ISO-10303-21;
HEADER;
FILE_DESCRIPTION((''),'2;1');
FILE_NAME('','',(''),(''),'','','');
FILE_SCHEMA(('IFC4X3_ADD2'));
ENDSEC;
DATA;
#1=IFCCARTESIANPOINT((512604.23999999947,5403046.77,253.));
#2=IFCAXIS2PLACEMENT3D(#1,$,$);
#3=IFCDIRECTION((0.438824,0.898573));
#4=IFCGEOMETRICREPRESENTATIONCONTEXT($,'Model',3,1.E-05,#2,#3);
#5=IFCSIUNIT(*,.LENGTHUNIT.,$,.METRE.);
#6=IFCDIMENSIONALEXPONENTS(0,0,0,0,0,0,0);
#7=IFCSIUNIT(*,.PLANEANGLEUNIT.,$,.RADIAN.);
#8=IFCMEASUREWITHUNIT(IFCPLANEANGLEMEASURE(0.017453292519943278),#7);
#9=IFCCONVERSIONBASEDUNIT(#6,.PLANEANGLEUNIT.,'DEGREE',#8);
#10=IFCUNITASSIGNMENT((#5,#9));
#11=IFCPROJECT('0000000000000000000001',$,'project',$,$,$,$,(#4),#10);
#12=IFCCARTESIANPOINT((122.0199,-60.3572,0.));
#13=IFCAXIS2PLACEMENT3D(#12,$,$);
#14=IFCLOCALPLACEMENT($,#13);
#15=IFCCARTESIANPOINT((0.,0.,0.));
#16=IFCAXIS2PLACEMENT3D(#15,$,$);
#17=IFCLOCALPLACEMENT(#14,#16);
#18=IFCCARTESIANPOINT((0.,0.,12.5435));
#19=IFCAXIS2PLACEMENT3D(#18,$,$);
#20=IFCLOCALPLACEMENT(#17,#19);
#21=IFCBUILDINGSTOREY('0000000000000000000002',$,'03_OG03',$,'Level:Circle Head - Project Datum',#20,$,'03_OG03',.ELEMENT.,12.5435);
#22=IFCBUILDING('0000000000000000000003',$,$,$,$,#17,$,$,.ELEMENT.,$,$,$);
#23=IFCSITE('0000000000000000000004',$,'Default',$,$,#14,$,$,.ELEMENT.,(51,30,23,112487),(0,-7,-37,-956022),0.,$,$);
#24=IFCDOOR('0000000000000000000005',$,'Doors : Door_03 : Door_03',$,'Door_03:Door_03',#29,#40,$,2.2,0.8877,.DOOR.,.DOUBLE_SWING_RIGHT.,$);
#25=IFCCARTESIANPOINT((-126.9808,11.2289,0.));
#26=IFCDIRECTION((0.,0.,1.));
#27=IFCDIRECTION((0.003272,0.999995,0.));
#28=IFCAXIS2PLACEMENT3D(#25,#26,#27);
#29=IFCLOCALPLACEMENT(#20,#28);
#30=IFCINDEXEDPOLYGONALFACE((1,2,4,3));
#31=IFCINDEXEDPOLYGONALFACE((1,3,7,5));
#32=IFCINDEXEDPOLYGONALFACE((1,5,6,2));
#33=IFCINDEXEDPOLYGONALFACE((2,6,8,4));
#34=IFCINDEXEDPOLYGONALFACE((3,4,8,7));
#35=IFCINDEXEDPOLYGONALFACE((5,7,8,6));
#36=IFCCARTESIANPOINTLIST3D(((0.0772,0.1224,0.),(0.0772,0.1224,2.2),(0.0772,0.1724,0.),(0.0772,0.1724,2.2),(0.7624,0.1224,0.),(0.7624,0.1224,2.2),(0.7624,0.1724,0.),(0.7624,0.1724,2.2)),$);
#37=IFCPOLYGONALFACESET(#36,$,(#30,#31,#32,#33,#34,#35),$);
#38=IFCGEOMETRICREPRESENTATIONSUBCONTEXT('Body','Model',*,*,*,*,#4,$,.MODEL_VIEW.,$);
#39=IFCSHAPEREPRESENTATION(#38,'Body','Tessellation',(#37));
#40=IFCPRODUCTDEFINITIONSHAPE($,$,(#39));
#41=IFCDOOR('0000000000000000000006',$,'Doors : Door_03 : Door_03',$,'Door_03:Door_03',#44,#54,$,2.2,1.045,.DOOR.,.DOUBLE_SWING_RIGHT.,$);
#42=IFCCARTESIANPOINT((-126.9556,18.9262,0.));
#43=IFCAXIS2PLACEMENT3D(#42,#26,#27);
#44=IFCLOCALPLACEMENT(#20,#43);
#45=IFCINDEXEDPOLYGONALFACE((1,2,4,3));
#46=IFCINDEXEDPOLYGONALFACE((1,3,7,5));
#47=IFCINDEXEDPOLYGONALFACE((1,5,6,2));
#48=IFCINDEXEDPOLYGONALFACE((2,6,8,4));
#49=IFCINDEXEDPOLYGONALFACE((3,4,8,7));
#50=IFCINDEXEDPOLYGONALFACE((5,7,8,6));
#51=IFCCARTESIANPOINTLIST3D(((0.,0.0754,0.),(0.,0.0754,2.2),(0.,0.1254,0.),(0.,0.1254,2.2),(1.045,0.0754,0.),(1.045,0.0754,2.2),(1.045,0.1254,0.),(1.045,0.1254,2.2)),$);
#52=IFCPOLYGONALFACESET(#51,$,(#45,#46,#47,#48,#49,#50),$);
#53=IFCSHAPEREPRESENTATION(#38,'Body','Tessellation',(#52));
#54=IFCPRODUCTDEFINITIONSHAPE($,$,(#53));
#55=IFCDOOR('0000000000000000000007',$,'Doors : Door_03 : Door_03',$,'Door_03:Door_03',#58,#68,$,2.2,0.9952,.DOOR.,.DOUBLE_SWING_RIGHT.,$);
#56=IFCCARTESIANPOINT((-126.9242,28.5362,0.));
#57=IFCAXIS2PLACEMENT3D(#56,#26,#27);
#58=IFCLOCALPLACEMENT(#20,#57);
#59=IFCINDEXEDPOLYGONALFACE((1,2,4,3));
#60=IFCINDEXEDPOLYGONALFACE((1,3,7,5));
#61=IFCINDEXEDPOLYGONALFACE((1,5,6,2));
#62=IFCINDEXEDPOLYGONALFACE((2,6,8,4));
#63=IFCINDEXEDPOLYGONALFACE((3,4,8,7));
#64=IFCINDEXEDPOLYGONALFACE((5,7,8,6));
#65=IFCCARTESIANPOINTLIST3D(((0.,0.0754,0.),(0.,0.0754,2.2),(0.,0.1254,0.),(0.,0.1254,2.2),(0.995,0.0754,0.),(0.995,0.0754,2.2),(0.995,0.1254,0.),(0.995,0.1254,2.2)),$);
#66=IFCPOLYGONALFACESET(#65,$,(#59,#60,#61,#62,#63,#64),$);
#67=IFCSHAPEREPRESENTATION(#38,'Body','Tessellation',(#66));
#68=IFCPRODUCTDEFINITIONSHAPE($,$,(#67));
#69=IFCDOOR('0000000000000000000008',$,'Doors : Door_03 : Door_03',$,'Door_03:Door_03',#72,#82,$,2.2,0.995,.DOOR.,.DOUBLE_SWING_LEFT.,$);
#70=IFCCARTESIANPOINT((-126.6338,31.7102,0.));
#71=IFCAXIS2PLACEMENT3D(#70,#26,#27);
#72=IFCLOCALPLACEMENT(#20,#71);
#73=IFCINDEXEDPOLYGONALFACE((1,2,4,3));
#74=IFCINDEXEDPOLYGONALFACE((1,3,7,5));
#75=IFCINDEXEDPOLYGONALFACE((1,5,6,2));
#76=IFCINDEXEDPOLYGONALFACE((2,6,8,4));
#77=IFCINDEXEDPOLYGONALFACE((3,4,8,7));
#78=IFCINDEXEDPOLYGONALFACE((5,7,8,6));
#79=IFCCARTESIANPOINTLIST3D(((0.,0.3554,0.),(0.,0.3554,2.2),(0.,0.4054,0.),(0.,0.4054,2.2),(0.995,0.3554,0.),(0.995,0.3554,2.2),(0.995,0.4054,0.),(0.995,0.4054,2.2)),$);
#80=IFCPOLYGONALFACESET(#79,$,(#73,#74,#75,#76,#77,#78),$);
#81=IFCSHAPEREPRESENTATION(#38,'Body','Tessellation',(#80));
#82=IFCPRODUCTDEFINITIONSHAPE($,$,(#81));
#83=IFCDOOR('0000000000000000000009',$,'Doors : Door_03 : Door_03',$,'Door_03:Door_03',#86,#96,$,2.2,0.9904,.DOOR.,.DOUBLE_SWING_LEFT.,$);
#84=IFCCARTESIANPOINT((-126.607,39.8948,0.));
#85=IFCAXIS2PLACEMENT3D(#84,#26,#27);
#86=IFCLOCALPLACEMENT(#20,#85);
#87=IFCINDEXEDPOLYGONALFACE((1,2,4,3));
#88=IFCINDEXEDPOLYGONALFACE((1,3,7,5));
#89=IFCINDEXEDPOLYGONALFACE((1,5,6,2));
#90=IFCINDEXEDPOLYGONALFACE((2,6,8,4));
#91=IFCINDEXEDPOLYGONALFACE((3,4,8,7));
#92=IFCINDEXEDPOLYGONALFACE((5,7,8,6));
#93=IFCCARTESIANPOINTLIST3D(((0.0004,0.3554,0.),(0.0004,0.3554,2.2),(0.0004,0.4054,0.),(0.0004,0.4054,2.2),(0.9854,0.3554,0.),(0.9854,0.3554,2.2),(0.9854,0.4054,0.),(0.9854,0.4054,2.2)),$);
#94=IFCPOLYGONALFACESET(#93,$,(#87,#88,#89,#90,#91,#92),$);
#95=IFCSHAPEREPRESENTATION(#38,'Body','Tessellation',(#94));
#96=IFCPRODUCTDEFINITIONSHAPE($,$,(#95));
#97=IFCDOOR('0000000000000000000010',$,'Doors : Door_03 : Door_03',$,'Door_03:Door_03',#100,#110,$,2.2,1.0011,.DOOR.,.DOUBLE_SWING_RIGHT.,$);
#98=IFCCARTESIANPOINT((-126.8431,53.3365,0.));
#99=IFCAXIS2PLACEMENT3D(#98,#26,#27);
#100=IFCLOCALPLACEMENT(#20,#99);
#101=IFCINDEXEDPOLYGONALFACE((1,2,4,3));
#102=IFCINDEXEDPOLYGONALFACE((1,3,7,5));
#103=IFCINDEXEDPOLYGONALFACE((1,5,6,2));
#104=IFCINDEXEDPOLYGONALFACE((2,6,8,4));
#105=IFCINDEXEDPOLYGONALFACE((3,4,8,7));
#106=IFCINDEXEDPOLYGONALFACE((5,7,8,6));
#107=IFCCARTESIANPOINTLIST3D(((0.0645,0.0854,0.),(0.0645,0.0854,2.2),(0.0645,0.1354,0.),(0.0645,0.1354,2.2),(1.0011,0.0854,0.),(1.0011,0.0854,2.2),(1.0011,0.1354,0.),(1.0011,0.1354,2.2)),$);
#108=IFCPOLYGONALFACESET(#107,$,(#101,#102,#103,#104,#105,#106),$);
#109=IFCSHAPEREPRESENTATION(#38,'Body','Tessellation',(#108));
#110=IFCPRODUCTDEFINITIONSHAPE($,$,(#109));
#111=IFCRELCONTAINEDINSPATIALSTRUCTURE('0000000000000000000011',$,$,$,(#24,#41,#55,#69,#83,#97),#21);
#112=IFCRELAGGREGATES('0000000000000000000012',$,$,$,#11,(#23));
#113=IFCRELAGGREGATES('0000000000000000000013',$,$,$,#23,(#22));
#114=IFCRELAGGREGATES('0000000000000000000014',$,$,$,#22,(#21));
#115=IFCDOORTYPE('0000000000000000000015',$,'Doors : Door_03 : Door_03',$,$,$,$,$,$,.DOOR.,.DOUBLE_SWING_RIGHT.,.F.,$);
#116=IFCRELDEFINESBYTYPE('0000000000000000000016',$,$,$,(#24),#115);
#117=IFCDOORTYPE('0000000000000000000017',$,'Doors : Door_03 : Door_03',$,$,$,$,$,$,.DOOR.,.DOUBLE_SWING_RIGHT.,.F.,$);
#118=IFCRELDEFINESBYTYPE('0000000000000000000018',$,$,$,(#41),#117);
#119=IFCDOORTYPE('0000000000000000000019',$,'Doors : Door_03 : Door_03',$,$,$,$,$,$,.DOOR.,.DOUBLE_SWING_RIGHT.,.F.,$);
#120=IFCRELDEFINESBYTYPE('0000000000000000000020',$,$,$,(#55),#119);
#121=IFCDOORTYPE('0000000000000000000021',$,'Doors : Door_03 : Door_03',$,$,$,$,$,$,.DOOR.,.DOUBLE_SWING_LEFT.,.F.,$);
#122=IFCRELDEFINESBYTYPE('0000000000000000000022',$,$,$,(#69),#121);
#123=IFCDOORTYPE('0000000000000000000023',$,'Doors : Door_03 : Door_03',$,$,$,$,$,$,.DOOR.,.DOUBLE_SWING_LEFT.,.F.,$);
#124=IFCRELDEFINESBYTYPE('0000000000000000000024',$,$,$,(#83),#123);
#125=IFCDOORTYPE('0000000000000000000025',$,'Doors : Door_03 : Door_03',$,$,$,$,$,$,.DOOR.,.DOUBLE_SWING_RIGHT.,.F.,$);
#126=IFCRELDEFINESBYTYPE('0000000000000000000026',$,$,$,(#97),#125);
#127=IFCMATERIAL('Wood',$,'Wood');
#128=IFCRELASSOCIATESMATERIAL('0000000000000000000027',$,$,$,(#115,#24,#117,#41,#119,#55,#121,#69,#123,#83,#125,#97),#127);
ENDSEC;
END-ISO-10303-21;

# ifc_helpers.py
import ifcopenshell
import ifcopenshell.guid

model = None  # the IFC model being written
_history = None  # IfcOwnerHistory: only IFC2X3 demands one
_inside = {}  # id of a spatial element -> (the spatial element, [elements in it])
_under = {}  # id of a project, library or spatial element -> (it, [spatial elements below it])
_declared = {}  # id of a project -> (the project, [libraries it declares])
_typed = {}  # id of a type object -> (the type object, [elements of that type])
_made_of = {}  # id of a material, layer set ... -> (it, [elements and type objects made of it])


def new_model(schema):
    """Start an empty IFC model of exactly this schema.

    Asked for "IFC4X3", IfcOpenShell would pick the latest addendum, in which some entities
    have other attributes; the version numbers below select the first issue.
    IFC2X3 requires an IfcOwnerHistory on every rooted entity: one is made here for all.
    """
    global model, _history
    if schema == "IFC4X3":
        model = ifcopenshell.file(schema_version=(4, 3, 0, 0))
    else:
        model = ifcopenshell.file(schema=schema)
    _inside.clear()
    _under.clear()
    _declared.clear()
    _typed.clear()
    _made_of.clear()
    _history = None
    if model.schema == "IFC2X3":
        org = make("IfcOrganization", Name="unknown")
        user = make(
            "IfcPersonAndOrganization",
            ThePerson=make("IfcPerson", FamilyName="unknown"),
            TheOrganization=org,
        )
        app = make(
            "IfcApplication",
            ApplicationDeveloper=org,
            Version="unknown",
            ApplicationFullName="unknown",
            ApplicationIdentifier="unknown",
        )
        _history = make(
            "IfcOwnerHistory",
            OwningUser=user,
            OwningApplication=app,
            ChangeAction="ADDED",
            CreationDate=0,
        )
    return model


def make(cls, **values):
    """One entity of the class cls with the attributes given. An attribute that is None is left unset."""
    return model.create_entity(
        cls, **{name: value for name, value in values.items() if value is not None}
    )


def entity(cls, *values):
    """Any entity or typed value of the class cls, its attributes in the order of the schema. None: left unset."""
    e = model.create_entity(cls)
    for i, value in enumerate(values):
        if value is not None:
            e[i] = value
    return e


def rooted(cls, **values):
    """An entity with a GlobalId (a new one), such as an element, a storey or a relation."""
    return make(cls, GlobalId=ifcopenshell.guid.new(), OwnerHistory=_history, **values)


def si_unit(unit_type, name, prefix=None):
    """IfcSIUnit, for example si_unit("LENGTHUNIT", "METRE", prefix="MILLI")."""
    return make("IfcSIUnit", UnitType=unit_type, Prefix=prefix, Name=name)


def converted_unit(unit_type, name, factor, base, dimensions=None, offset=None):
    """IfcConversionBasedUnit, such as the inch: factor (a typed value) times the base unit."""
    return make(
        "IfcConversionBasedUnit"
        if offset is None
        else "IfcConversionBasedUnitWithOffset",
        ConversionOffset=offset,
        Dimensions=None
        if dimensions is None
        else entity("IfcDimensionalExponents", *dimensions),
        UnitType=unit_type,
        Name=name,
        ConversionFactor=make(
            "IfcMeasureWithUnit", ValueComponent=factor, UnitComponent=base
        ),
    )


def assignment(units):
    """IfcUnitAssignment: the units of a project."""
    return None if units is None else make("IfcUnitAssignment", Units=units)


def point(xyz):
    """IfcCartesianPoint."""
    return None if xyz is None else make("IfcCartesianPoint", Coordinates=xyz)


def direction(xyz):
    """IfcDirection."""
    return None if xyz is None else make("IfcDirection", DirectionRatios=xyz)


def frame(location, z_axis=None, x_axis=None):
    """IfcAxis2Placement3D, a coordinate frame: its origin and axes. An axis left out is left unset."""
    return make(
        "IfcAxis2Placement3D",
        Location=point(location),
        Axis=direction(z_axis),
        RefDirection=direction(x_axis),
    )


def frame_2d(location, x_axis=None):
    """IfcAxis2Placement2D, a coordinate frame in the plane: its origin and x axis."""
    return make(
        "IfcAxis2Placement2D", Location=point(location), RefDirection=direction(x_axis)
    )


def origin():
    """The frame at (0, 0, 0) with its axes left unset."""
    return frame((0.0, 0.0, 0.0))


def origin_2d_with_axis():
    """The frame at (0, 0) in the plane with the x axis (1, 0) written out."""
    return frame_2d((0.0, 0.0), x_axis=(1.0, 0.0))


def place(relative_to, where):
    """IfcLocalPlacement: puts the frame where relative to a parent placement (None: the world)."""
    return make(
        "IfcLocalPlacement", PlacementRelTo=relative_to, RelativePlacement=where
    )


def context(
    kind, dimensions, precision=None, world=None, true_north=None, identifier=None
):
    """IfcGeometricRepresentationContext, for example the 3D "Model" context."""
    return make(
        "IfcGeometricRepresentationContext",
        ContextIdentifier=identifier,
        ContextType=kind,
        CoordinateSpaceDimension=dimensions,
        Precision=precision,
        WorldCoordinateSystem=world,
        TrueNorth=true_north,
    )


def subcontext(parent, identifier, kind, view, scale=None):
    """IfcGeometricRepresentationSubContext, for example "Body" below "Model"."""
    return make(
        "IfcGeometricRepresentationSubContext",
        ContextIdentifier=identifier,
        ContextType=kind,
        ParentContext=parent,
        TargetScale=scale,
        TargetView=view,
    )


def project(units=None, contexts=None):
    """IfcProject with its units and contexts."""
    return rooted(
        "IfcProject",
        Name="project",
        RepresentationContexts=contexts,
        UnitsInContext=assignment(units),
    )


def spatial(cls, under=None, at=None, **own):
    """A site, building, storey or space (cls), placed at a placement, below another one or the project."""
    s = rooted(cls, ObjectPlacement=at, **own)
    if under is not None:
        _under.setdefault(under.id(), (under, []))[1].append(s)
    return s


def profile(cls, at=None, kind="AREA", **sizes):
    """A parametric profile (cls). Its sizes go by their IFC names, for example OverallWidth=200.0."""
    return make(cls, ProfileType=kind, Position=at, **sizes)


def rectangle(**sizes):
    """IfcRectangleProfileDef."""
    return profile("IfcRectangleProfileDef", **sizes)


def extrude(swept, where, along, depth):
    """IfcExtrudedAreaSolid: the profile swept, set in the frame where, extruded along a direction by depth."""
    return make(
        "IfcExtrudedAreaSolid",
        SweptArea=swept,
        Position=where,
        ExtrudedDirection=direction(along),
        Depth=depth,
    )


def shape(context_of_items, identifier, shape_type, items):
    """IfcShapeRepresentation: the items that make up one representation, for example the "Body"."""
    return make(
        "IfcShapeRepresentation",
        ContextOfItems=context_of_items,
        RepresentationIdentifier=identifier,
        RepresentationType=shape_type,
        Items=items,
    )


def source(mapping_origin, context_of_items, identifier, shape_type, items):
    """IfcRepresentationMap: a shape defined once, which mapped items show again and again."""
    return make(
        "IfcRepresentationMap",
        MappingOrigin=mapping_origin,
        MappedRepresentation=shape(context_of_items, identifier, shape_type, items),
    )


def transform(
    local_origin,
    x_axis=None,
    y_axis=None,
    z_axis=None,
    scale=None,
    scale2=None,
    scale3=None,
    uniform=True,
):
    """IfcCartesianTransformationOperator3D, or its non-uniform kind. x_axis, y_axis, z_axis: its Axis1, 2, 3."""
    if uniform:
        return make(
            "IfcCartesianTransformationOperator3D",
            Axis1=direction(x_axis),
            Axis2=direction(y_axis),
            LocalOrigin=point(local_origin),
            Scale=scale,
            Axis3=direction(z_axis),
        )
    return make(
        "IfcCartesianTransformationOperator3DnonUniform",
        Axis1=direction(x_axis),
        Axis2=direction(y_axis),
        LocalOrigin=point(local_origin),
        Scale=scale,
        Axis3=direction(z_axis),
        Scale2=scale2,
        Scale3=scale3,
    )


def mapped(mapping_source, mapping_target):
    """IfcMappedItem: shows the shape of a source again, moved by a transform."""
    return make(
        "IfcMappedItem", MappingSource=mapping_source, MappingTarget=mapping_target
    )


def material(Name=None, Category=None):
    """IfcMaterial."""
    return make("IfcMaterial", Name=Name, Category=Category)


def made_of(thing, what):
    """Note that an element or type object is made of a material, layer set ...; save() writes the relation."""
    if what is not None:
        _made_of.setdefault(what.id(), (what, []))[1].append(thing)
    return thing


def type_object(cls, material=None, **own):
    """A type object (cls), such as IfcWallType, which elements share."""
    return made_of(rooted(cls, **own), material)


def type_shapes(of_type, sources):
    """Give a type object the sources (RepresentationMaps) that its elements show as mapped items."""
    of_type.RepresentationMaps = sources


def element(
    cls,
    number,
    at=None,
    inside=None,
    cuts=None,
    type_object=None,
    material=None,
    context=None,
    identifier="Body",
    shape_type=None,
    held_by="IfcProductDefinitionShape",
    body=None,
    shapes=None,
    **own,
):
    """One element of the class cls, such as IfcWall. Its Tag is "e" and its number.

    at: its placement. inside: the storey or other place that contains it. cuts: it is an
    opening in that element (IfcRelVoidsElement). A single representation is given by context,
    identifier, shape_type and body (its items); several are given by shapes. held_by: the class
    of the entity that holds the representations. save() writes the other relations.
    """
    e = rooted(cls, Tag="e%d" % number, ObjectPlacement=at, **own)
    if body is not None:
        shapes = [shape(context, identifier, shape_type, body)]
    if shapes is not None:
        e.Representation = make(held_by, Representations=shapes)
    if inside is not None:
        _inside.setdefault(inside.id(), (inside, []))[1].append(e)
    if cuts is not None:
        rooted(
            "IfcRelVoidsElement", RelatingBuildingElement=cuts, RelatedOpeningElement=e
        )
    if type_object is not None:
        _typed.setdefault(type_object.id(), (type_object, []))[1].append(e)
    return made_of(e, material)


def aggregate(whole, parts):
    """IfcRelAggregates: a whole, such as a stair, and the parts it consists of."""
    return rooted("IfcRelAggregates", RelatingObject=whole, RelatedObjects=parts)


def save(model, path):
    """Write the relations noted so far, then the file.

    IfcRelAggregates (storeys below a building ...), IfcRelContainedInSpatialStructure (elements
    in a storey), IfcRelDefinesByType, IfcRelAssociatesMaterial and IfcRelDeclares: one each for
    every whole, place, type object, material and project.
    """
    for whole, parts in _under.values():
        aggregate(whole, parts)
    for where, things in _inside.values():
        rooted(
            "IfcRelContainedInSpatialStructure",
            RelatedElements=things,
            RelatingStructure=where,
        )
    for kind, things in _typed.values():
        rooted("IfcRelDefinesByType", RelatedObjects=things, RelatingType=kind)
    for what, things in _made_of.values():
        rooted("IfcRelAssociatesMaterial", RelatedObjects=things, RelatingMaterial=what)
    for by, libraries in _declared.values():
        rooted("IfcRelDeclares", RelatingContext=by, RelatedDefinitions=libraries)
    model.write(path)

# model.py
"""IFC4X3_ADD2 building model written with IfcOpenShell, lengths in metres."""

from ifc_helpers import new_model, entity, si_unit, converted_unit, direction, frame, frame_2d, origin, origin_2d_with_axis, place, context, subcontext, project, spatial, rectangle, extrude, source, transform, mapped, material, type_object, type_shapes, element, save


model = new_model("IFC4X3_ADD2")

# Units and contexts
model_context = context("Model", 3, precision=1e-05, world=frame((512604.23999999947, 5403046.77, 253.0)), true_north=direction((0.438824, 0.898573)))
body_context = subcontext(model_context, "Body", "Model", "MODEL_VIEW")
ifc_project = project(units=[si_unit("LENGTHUNIT", "METRE"), converted_unit("PLANEANGLEUNIT", "DEGREE", entity("IfcPlaneAngleMeasure", 0.017453292519943278), si_unit("PLANEANGLEUNIT", "RADIAN"), dimensions=[0, 0, 0, 0, 0, 0, 0])], contexts=[model_context])

# Site, building, storey
site_placement = place(None, frame((122.0199, -60.3572, 0.0)))
site = spatial("IfcSite", under=ifc_project, at=site_placement, Name="Default", CompositionType="ELEMENT", RefLatitude=(51, 30, 23, 112487), RefLongitude=(0, -7, -37, -956022), RefElevation=0.0)
building_placement = place(site_placement, origin())
building = spatial("IfcBuilding", under=site, at=building_placement, CompositionType="ELEMENT")
storey_placement = place(building_placement, frame((0.0, 0.0, 12.5435)))
storey = spatial("IfcBuildingStorey", under=building, at=storey_placement, Name="03_OG03", ObjectType="Level:Circle Head - Project Datum", LongName="03_OG03", CompositionType="ELEMENT", Elevation=12.5435)

# Shared definitions
ifc_material_1 = material(Name="Wood", Category="Wood")

# Doors
door_type_1 = type_object("IfcDoorType", Name="Doors : Door_03 : Door_03", OperationType="DOUBLE_SWING_RIGHT", ParameterTakesPrecedence=False, PredefinedType="DOOR", material=ifc_material_1)
shared_shape_1 = source(origin(), body_context, "Body", "SweptSolid", [
    extrude(rectangle(XDim=0.05, YDim=0.6852, at=origin_2d_with_axis()), frame((0.4198, 0.1474, 0.0), z_axis=(0.0, 0.0, 1.0), x_axis=(0.0, 1.0, 0.0)), (0.0, 0.0, 1.0), 2.2),
])
type_shapes(door_type_1, [shared_shape_1])
door_1_placement = place(storey_placement, frame((-126.9808, 11.2289, 0.0), z_axis=(0.0, 0.0, 1.0), x_axis=(0.003272, 0.999995, 0.0)))
element("IfcDoor", 1, at=door_1_placement, inside=storey, type_object=door_type_1, material=ifc_material_1, Name="Doors : Door_03 : Door_03", ObjectType="Door_03:Door_03", OperationType="DOUBLE_SWING_RIGHT", OverallHeight=2.2, OverallWidth=0.8877, PredefinedType="DOOR", context=body_context, shape_type="MappedRepresentation", body=[
    mapped(shared_shape_1, transform((0.0, 0.0, 0.0), scale=1.0)),
])
door_type_2 = type_object("IfcDoorType", Name="Doors : Door_03 : Door_03", OperationType="DOUBLE_SWING_RIGHT", ParameterTakesPrecedence=False, PredefinedType="DOOR", material=ifc_material_1)
shared_shape_2 = source(origin(), body_context, "Body", "SweptSolid", [
    extrude(rectangle(XDim=0.05, YDim=1.045, at=frame_2d((0.0, 0.0), x_axis=(1.0, 0.0))), frame((0.5225, 0.1004, 0.0), z_axis=(0.0, 0.0, 1.0), x_axis=(0.0, 1.0, 0.0)), (0.0, 0.0, 1.0), 2.2),
])
type_shapes(door_type_2, [shared_shape_2])
door_2_placement = place(storey_placement, frame((-126.9556, 18.9262, 0.0), z_axis=(0.0, 0.0, 1.0), x_axis=(0.003272, 0.999995, 0.0)))
element("IfcDoor", 2, at=door_2_placement, inside=storey, type_object=door_type_2, material=ifc_material_1, Name="Doors : Door_03 : Door_03", ObjectType="Door_03:Door_03", OperationType="DOUBLE_SWING_RIGHT", OverallHeight=2.2, OverallWidth=1.045, PredefinedType="DOOR", context=body_context, shape_type="MappedRepresentation", body=[
    mapped(shared_shape_2, transform((0.0, 0.0, 0.0), scale=1.0)),
])
door_type_3 = type_object("IfcDoorType", Name="Doors : Door_03 : Door_03", OperationType="DOUBLE_SWING_RIGHT", ParameterTakesPrecedence=False, PredefinedType="DOOR", material=ifc_material_1)
shared_shape_3 = source(origin(), body_context, "Body", "SweptSolid", [
    extrude(rectangle(XDim=0.05, YDim=0.995, at=frame_2d((0.0, 0.0), x_axis=(1.0, 0.0))), frame((0.4975, 0.1004, 0.0), z_axis=(0.0, 0.0, 1.0), x_axis=(0.0, 1.0, 0.0)), (0.0, 0.0, 1.0), 2.2),
])
type_shapes(door_type_3, [shared_shape_3])
door_3_placement = place(storey_placement, frame((-126.9242, 28.5362, 0.0), z_axis=(0.0, 0.0, 1.0), x_axis=(0.003272, 0.999995, 0.0)))
element("IfcDoor", 3, at=door_3_placement, inside=storey, type_object=door_type_3, material=ifc_material_1, Name="Doors : Door_03 : Door_03", ObjectType="Door_03:Door_03", OperationType="DOUBLE_SWING_RIGHT", OverallHeight=2.2, OverallWidth=0.9952, PredefinedType="DOOR", context=body_context, shape_type="MappedRepresentation", body=[
    mapped(shared_shape_3, transform((0.0, 0.0, 0.0), scale=1.0)),
])
door_type_4 = type_object("IfcDoorType", Name="Doors : Door_03 : Door_03", OperationType="DOUBLE_SWING_LEFT", ParameterTakesPrecedence=False, PredefinedType="DOOR", material=ifc_material_1)
shared_shape_4 = source(origin(), body_context, "Body", "SweptSolid", [
    extrude(rectangle(XDim=0.995, YDim=0.05, at=frame_2d((0.0, 0.0), x_axis=(1.0, 0.0))), frame((0.4975, 0.3804, 0.0)), (0.0, 0.0, 1.0), 2.2),
])
type_shapes(door_type_4, [shared_shape_4])
door_4_placement = place(storey_placement, frame((-126.6338, 31.7102, 0.0), z_axis=(0.0, 0.0, 1.0), x_axis=(0.003272, 0.999995, 0.0)))
element("IfcDoor", 4, at=door_4_placement, inside=storey, type_object=door_type_4, material=ifc_material_1, Name="Doors : Door_03 : Door_03", ObjectType="Door_03:Door_03", OperationType="DOUBLE_SWING_LEFT", OverallHeight=2.2, OverallWidth=0.995, PredefinedType="DOOR", context=body_context, shape_type="MappedRepresentation", body=[
    mapped(shared_shape_4, transform((0.0, 0.0, 0.0), scale=1.0)),
])
door_type_5 = type_object("IfcDoorType", Name="Doors : Door_03 : Door_03", OperationType="DOUBLE_SWING_LEFT", ParameterTakesPrecedence=False, PredefinedType="DOOR", material=ifc_material_1)
shared_shape_5 = source(origin(), body_context, "Body", "SweptSolid", [
    extrude(rectangle(XDim=0.985, YDim=0.05, at=frame_2d((0.0, 0.0), x_axis=(1.0, 0.0))), frame((0.4929, 0.3804, 0.0)), (0.0, 0.0, 1.0), 2.2),
])
type_shapes(door_type_5, [shared_shape_5])
door_5_placement = place(storey_placement, frame((-126.607, 39.8948, 0.0), z_axis=(0.0, 0.0, 1.0), x_axis=(0.003272, 0.999995, 0.0)))
element("IfcDoor", 5, at=door_5_placement, inside=storey, type_object=door_type_5, material=ifc_material_1, Name="Doors : Door_03 : Door_03", ObjectType="Door_03:Door_03", OperationType="DOUBLE_SWING_LEFT", OverallHeight=2.2, OverallWidth=0.9904, PredefinedType="DOOR", context=body_context, shape_type="MappedRepresentation", body=[
    mapped(shared_shape_5, transform((0.0, 0.0, 0.0), scale=1.0)),
])
door_type_6 = type_object("IfcDoorType", Name="Doors : Door_03 : Door_03", OperationType="DOUBLE_SWING_RIGHT", ParameterTakesPrecedence=False, PredefinedType="DOOR", material=ifc_material_1)
shared_shape_6 = source(origin(), body_context, "Body", "SweptSolid", [
    extrude(rectangle(XDim=0.05, YDim=0.9366, at=origin_2d_with_axis()), frame((0.5328, 0.1104, 0.0), z_axis=(0.0, 0.0, 1.0), x_axis=(0.0, 1.0, 0.0)), (0.0, 0.0, 1.0), 2.2),
])
type_shapes(door_type_6, [shared_shape_6])
door_6_placement = place(storey_placement, frame((-126.8431, 53.3365, 0.0), z_axis=(0.0, 0.0, 1.0), x_axis=(0.003272, 0.999995, 0.0)))
element("IfcDoor", 6, at=door_6_placement, inside=storey, type_object=door_type_6, material=ifc_material_1, Name="Doors : Door_03 : Door_03", ObjectType="Door_03:Door_03", OperationType="DOUBLE_SWING_RIGHT", OverallHeight=2.2, OverallWidth=1.0011, PredefinedType="DOOR", context=body_context, shape_type="MappedRepresentation", body=[
    mapped(shared_shape_6, transform((0.0, 0.0, 0.0), scale=1.0)),
])

save(model, "model.ifc")
